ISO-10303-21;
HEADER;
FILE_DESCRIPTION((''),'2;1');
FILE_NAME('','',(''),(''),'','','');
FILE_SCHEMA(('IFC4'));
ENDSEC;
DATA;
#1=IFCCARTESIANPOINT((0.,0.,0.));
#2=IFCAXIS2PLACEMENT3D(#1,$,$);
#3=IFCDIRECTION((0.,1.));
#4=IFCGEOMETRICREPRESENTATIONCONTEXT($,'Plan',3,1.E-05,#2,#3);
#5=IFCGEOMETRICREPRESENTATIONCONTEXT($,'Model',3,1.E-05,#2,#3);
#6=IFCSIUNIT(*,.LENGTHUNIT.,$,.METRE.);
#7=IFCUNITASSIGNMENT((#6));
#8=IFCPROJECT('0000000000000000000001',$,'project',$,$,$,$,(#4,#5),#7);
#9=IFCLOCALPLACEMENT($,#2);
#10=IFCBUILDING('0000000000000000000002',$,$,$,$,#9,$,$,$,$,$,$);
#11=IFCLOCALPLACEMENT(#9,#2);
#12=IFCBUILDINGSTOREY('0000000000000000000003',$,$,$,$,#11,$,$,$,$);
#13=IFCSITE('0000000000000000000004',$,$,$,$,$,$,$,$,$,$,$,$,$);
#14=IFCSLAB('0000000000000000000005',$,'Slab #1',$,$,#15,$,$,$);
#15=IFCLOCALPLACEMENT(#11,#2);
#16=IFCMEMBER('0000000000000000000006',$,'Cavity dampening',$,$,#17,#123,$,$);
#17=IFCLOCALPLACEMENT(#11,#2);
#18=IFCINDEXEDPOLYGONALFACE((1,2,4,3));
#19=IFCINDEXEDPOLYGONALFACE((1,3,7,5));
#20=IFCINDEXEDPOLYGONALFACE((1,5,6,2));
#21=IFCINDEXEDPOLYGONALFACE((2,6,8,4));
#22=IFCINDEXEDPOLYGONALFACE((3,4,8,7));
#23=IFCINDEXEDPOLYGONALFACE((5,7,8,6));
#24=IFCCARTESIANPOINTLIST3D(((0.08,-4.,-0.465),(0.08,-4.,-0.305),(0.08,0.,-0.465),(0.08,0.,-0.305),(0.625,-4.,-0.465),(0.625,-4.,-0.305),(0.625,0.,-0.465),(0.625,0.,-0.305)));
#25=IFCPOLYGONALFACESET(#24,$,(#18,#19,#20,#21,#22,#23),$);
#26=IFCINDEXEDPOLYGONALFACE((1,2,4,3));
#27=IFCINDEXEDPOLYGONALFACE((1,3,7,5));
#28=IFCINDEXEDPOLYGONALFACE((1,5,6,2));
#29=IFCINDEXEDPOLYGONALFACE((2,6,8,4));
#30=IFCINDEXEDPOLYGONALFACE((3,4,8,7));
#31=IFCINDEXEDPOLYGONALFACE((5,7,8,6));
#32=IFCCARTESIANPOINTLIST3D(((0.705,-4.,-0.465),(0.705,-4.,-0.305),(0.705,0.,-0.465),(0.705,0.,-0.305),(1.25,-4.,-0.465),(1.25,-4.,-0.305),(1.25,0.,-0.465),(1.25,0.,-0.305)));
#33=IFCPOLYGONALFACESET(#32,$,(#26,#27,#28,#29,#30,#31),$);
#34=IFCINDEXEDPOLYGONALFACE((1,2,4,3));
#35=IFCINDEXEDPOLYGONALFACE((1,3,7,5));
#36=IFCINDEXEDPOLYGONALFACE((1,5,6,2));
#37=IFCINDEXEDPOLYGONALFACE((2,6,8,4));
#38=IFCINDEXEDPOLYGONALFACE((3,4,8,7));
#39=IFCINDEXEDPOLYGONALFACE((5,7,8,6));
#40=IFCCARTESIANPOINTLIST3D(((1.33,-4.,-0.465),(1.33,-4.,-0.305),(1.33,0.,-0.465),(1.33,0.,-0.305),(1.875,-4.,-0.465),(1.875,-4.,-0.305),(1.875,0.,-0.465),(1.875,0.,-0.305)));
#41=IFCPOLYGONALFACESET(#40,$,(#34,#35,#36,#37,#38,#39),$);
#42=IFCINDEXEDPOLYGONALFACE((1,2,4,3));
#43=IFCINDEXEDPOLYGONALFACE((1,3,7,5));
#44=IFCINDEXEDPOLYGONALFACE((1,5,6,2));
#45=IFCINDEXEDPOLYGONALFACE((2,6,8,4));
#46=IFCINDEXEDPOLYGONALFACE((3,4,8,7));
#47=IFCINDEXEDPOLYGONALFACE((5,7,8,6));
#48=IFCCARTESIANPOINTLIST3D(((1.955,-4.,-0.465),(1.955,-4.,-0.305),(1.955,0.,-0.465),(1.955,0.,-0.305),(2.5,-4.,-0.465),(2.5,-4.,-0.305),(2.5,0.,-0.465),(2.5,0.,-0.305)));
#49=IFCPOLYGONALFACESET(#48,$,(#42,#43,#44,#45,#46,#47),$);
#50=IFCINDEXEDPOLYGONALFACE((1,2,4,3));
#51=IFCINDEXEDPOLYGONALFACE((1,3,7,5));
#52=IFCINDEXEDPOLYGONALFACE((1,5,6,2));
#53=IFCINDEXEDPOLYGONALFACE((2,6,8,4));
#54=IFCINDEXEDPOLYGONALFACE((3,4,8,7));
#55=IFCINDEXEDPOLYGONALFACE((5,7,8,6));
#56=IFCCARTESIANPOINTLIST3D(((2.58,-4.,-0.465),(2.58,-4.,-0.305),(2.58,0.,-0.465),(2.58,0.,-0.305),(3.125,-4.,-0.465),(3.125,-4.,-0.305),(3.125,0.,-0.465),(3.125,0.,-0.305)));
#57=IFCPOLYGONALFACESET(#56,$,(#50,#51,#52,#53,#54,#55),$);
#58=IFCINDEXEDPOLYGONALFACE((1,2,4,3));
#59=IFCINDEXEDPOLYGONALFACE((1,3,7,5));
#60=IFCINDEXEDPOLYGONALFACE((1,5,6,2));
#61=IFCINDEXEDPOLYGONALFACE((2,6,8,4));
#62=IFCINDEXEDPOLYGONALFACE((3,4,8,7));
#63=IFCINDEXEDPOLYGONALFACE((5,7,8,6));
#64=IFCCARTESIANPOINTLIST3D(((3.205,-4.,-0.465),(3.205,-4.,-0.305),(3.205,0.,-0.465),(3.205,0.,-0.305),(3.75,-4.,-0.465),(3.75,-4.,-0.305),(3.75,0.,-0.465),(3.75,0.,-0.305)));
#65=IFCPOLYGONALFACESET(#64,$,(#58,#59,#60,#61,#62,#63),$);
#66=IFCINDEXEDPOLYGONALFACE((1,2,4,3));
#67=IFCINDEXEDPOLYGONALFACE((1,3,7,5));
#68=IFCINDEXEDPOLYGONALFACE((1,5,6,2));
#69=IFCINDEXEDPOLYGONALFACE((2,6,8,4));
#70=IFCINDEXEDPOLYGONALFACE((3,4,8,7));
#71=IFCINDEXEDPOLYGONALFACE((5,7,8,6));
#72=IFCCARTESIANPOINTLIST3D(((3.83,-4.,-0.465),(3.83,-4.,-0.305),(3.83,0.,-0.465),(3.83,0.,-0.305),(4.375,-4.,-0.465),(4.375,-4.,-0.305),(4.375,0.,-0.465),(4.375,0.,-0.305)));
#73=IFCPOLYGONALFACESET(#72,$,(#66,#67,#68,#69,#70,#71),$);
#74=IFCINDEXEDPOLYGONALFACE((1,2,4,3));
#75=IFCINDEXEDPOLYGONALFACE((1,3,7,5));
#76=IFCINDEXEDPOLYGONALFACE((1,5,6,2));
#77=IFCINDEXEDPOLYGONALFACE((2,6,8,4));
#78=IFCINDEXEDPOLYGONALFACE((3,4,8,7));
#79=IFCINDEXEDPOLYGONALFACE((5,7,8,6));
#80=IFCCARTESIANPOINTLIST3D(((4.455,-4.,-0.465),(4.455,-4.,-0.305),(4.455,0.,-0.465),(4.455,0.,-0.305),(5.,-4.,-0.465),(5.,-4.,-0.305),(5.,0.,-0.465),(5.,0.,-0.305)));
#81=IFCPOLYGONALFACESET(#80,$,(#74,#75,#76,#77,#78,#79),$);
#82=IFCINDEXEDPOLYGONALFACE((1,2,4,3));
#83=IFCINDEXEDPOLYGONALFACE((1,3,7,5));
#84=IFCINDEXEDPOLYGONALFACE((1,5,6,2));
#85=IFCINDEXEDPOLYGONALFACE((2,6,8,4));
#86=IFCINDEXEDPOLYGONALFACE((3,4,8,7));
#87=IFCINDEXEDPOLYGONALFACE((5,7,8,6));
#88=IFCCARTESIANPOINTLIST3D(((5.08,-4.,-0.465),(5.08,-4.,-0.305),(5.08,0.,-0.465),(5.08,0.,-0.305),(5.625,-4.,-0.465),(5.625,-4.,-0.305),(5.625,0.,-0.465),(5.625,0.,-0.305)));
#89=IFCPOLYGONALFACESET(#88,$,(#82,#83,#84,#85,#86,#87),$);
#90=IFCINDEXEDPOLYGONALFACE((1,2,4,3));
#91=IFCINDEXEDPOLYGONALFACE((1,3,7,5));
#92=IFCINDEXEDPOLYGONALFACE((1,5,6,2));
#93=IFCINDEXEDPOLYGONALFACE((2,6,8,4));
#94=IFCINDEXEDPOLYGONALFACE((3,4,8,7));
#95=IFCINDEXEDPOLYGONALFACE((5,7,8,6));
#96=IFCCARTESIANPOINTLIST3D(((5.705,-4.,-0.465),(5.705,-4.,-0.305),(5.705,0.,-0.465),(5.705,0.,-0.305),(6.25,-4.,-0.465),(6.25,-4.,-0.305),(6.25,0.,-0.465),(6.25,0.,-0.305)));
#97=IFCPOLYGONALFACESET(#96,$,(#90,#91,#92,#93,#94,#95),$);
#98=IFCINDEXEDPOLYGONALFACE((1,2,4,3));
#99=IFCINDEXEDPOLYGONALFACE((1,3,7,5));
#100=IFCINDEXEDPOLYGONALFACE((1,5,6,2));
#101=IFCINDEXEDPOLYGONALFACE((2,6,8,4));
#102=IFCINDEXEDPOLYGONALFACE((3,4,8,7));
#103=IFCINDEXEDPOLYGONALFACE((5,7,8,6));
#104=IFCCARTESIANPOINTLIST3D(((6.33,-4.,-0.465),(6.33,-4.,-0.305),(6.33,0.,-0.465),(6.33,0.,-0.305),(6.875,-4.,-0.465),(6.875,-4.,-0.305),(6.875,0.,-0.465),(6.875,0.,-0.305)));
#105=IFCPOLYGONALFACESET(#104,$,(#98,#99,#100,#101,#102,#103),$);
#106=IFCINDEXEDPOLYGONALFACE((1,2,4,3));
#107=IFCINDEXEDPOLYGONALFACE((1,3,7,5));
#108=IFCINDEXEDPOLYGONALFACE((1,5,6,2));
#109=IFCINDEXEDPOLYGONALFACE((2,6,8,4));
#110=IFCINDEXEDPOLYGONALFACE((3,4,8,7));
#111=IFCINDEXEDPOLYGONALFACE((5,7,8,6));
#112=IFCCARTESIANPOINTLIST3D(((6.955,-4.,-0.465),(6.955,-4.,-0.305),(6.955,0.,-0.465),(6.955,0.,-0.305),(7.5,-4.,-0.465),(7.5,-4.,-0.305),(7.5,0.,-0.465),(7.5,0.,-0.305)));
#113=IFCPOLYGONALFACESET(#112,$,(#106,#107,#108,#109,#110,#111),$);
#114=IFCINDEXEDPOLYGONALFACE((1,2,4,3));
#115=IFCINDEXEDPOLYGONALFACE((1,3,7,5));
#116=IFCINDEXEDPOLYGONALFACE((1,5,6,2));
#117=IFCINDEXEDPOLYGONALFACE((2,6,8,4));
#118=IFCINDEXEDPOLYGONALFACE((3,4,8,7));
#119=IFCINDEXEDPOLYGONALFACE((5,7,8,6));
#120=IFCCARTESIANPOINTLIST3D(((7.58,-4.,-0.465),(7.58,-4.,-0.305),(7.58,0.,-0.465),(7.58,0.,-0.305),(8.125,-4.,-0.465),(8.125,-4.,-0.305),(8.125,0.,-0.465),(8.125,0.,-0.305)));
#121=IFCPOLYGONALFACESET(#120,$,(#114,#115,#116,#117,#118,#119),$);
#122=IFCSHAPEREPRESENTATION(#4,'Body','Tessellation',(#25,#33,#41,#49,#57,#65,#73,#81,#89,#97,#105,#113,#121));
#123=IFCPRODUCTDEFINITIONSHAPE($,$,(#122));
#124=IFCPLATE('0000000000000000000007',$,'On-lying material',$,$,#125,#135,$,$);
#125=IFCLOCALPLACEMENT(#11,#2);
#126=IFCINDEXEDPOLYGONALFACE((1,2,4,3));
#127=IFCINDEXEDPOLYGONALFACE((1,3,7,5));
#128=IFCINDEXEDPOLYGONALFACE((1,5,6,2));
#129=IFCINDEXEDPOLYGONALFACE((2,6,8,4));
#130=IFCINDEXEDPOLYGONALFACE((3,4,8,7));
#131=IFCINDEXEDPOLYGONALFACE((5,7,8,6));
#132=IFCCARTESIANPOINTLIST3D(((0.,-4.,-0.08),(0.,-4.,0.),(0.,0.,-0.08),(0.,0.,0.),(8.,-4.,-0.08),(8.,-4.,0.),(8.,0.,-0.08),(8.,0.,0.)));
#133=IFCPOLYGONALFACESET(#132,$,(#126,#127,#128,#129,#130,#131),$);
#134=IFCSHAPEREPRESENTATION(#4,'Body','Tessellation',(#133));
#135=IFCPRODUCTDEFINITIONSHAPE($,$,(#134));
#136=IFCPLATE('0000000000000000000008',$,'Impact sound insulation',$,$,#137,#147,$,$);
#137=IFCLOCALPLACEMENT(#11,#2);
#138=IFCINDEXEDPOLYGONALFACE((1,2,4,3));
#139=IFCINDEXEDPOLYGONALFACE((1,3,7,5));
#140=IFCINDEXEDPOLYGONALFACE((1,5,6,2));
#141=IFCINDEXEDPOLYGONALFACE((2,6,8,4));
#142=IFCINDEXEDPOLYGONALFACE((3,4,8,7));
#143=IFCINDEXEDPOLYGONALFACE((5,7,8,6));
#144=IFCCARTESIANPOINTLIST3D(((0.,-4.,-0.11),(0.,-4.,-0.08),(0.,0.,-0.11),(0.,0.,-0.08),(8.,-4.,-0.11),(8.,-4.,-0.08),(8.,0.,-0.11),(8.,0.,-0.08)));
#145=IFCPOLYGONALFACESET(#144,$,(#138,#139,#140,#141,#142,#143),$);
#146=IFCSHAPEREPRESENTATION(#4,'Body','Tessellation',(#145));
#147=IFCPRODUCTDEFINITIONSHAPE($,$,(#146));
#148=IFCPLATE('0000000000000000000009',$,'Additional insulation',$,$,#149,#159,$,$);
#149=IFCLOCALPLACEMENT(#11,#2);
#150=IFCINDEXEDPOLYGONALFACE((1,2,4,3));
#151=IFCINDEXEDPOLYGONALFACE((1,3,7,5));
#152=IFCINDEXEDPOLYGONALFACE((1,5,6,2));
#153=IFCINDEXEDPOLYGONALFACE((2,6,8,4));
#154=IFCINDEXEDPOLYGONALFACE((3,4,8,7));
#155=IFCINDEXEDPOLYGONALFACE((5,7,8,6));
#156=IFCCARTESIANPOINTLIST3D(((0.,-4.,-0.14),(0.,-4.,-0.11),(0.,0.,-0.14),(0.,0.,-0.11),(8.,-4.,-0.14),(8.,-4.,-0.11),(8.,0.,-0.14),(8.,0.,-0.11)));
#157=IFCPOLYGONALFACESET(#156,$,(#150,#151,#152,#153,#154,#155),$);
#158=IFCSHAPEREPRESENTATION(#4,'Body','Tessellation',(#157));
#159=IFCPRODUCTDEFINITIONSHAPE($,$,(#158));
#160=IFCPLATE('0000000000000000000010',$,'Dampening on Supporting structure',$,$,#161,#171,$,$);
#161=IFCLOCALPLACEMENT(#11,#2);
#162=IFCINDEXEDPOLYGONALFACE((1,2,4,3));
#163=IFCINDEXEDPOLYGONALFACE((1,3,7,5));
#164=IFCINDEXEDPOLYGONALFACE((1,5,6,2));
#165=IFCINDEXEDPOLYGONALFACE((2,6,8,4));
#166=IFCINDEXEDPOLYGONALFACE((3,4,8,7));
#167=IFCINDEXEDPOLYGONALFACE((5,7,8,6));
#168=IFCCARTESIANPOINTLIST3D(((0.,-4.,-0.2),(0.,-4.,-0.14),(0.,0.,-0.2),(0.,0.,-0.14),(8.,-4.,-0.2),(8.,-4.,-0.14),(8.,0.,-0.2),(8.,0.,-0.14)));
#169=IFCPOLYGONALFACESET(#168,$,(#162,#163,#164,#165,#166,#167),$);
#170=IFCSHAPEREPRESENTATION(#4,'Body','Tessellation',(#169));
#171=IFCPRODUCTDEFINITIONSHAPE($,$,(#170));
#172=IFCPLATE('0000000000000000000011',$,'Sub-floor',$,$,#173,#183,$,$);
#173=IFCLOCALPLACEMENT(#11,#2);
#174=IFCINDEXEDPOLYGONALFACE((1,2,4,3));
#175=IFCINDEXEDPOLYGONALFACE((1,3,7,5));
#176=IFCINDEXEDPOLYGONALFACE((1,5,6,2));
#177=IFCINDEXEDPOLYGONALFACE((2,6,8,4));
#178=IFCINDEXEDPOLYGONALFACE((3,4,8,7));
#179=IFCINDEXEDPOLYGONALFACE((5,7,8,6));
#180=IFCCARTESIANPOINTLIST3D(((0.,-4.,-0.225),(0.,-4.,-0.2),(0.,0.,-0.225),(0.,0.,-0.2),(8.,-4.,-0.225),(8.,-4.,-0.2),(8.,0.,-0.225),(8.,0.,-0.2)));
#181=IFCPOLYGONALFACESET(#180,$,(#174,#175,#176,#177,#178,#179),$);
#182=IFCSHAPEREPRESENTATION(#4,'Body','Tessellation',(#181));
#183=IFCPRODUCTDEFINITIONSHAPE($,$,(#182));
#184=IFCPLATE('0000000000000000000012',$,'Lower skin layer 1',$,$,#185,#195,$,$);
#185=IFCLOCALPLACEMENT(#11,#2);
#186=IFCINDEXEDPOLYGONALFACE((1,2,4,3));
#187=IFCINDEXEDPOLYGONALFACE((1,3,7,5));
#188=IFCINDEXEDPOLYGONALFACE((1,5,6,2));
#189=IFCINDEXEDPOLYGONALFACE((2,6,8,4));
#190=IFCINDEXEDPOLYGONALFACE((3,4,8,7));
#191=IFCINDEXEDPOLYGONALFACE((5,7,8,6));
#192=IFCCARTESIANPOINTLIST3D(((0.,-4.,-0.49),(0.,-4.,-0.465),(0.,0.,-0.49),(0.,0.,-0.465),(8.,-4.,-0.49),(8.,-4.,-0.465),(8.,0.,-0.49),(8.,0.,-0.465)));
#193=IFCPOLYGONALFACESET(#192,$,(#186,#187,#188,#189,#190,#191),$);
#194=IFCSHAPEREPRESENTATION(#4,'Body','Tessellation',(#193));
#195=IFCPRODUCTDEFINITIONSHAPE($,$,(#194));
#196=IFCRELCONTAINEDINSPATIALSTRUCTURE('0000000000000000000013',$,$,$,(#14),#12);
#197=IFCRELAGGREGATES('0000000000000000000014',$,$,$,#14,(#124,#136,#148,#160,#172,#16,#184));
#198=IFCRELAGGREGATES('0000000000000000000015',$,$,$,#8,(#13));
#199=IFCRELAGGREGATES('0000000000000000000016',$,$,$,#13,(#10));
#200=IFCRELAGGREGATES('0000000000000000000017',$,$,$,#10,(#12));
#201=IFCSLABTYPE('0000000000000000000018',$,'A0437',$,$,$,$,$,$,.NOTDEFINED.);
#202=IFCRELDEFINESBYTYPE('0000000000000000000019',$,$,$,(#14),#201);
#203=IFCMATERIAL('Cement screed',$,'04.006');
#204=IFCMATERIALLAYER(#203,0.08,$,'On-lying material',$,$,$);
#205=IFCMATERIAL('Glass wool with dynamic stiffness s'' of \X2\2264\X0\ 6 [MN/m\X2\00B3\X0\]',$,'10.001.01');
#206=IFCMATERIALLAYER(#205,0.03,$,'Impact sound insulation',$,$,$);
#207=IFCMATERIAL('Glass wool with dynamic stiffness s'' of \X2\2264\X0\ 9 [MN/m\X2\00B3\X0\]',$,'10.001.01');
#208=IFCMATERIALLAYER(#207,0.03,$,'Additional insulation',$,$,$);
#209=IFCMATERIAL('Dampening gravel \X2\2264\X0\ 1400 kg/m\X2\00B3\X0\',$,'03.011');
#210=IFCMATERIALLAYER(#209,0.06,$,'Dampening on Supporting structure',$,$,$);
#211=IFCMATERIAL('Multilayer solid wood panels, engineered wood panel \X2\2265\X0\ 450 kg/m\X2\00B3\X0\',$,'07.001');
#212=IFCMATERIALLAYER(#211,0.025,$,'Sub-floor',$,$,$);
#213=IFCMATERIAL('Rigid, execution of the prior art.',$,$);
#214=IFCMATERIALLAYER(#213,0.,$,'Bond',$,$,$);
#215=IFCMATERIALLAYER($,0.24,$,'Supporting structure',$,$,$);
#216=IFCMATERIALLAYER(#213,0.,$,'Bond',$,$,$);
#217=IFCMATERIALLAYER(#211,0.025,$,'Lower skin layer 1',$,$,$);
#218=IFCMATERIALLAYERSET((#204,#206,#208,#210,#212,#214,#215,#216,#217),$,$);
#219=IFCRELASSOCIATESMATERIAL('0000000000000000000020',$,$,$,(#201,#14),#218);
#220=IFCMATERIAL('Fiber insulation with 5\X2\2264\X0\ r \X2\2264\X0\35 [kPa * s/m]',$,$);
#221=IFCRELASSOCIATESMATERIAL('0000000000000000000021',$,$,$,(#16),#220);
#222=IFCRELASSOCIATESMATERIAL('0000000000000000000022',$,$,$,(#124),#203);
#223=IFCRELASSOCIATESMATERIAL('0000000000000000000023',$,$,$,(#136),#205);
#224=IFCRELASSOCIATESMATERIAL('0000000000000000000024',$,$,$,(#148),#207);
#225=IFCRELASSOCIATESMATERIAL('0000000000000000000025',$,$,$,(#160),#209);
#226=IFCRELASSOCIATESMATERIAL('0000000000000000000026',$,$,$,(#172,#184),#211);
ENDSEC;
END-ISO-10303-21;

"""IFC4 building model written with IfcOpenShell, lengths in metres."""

from ifc_helpers import new_model, si_unit, direction, frame, frame_2d, origin, origin_with_axes, place, context, project, spatial, rectangle, extrude, material, layer, layer_set, type_object, element, aggregate, save


model = new_model("IFC4")

# Units and contexts
plan_context = context("Plan", 3, precision=1e-05, world=origin(), true_north=direction((0.0, 1.0)))
model_context = context("Model", 3, precision=1e-05, world=origin(), true_north=direction((0.0, 1.0)))
ifc_project = project(units=[si_unit("LENGTHUNIT", "METRE")], contexts=[plan_context, model_context])

# Site, building, storey
site = spatial("IfcSite", under=ifc_project)
building_placement = place(None, origin())
building = spatial("IfcBuilding", under=site, at=building_placement)
storey_placement = place(building_placement, origin())
storey = spatial("IfcBuildingStorey", under=building, at=storey_placement)

# Slab, member, plates
ifc_material_1 = material(Name="Cement screed", Category="04.006")
ifc_layer_1 = layer(ifc_material_1, 0.08, Name="On-lying material")
ifc_material_2 = material(Name="Glass wool with dynamic stiffness s' of ≤ 6 [MN/m³]", Category="10.001.01")
ifc_layer_2 = layer(ifc_material_2, 0.03, Name="Impact sound insulation")
ifc_material_3 = material(Name="Glass wool with dynamic stiffness s' of ≤ 9 [MN/m³]", Category="10.001.01")
ifc_layer_3 = layer(ifc_material_3, 0.03, Name="Additional insulation")
ifc_material_4 = material(Name="Dampening gravel ≤ 1400 kg/m³", Category="03.011")
ifc_layer_4 = layer(ifc_material_4, 0.06, Name="Dampening on Supporting structure")
ifc_material_5 = material(Name="Multilayer solid wood panels, engineered wood panel ≥ 450 kg/m³", Category="07.001")
ifc_layer_5 = layer(ifc_material_5, 0.025, Name="Sub-floor")
ifc_material_6 = material(Name="Rigid, execution of the prior art.")
ifc_layer_6 = layer(ifc_material_6, 0.0, Name="Bond")
ifc_layer_7 = layer(None, 0.24, Name="Supporting structure")
ifc_layer_8 = layer(ifc_material_6, 0.0, Name="Bond")
ifc_layer_9 = layer(ifc_material_5, 0.025, Name="Lower skin layer 1")
ifc_layer_set = layer_set([ifc_layer_1, ifc_layer_2, ifc_layer_3, ifc_layer_4, ifc_layer_5, ifc_layer_6, ifc_layer_7, ifc_layer_8, ifc_layer_9])
slab_type = type_object("IfcSlabType", Name="A0437", PredefinedType="NOTDEFINED", material=ifc_layer_set)
slab_placement = place(None, frame((0.0, 0.0, 0.0), z_axis=(0.0, 0.0, -1.0), x_axis=(1.0, 0.0, 0.0)))
slab = element("IfcSlab", 1, at=slab_placement, inside=storey, type_object=slab_type, material=ifc_layer_set, Name="Slab #1")
ifc_material_7 = material(Name="Fiber insulation with 5≤ r ≤35 [kPa * s/m]")
member_1_placement = place(slab_placement, origin())
member_1 = element("IfcMember", 2, at=member_1_placement, material=ifc_material_7, Name="Cavity dampening", context=plan_context, shape_type="SweptSolid", body=[
    extrude(rectangle(XDim=0.545, YDim=0.16, at=frame_2d((0.2725, 0.08), x_axis=(1.0, 0.0))), frame((0.08, 4.0, 0.305), z_axis=(0.0, -1.0, 0.0), x_axis=(1.0, 0.0, 0.0)), (0.0, 0.0, 1.0), 4.0),
    extrude(rectangle(XDim=0.545, YDim=0.16, at=frame_2d((0.2725, 0.08), x_axis=(1.0, 0.0))), frame((0.705, 4.0, 0.305), z_axis=(0.0, -1.0, 0.0), x_axis=(1.0, 0.0, 0.0)), (0.0, 0.0, 1.0), 4.0),
    extrude(rectangle(XDim=0.545, YDim=0.16, at=frame_2d((0.2725, 0.08), x_axis=(1.0, 0.0))), frame((1.33, 4.0, 0.305), z_axis=(0.0, -1.0, 0.0), x_axis=(1.0, 0.0, 0.0)), (0.0, 0.0, 1.0), 4.0),
    extrude(rectangle(XDim=0.545, YDim=0.16, at=frame_2d((0.2725, 0.08), x_axis=(1.0, 0.0))), frame((1.955, 4.0, 0.305), z_axis=(0.0, -1.0, 0.0), x_axis=(1.0, 0.0, 0.0)), (0.0, 0.0, 1.0), 4.0),
    extrude(rectangle(XDim=0.545, YDim=0.16, at=frame_2d((0.2725, 0.08), x_axis=(1.0, 0.0))), frame((2.58, 4.0, 0.305), z_axis=(0.0, -1.0, 0.0), x_axis=(1.0, 0.0, 0.0)), (0.0, 0.0, 1.0), 4.0),
    extrude(rectangle(XDim=0.545, YDim=0.16, at=frame_2d((0.2725, 0.08), x_axis=(1.0, 0.0))), frame((3.205, 4.0, 0.305), z_axis=(0.0, -1.0, 0.0), x_axis=(1.0, 0.0, 0.0)), (0.0, 0.0, 1.0), 4.0),
    extrude(rectangle(XDim=0.545, YDim=0.16, at=frame_2d((0.2725, 0.08), x_axis=(1.0, 0.0))), frame((3.83, 4.0, 0.305), z_axis=(0.0, -1.0, 0.0), x_axis=(1.0, 0.0, 0.0)), (0.0, 0.0, 1.0), 4.0),
    extrude(rectangle(XDim=0.545, YDim=0.16, at=frame_2d((0.2725, 0.08), x_axis=(1.0, 0.0))), frame((4.455, 4.0, 0.305), z_axis=(0.0, -1.0, 0.0), x_axis=(1.0, 0.0, 0.0)), (0.0, 0.0, 1.0), 4.0),
    extrude(rectangle(XDim=0.545, YDim=0.16, at=frame_2d((0.2725, 0.08), x_axis=(1.0, 0.0))), frame((5.08, 4.0, 0.305), z_axis=(0.0, -1.0, 0.0), x_axis=(1.0, 0.0, 0.0)), (0.0, 0.0, 1.0), 4.0),
    extrude(rectangle(XDim=0.545, YDim=0.16, at=frame_2d((0.2725, 0.08), x_axis=(1.0, 0.0))), frame((5.705, 4.0, 0.305), z_axis=(0.0, -1.0, 0.0), x_axis=(1.0, 0.0, 0.0)), (0.0, 0.0, 1.0), 4.0),
    extrude(rectangle(XDim=0.545, YDim=0.16, at=frame_2d((0.2725, 0.08), x_axis=(1.0, 0.0))), frame((6.33, 4.0, 0.305), z_axis=(0.0, -1.0, 0.0), x_axis=(1.0, 0.0, 0.0)), (0.0, 0.0, 1.0), 4.0),
    extrude(rectangle(XDim=0.545, YDim=0.16, at=frame_2d((0.2725, 0.08), x_axis=(1.0, 0.0))), frame((6.955, 4.0, 0.305), z_axis=(0.0, -1.0, 0.0), x_axis=(1.0, 0.0, 0.0)), (0.0, 0.0, 1.0), 4.0),
    extrude(rectangle(XDim=0.545, YDim=0.16, at=frame_2d((0.2725, 0.08), x_axis=(1.0, 0.0))), frame((7.58, 4.0, 0.305), z_axis=(0.0, -1.0, 0.0), x_axis=(1.0, 0.0, 0.0)), (0.0, 0.0, 1.0), 4.0),
])
plate_1_placement = place(slab_placement, origin())
plate_1 = element("IfcPlate", 3, at=plate_1_placement, material=ifc_material_1, Name="On-lying material", context=plan_context, shape_type="SweptSolid", body=[
    extrude(rectangle(XDim=8.0, YDim=4.0, at=frame_2d((4.0, 2.0), x_axis=(1.0, 0.0))), origin_with_axes(), (0.0, 0.0, 1.0), 0.08),
])
plate_2_placement = place(slab_placement, origin())
plate_2 = element("IfcPlate", 4, at=plate_2_placement, material=ifc_material_2, Name="Impact sound insulation", context=plan_context, shape_type="SweptSolid", body=[
    extrude(rectangle(XDim=8.0, YDim=4.0, at=frame_2d((4.0, 2.0), x_axis=(1.0, 0.0))), frame((0.0, 0.0, 0.08), z_axis=(0.0, 0.0, 1.0), x_axis=(1.0, 0.0, 0.0)), (0.0, 0.0, 1.0), 0.03),
])
plate_3_placement = place(slab_placement, origin())
plate_3 = element("IfcPlate", 5, at=plate_3_placement, material=ifc_material_3, Name="Additional insulation", context=plan_context, shape_type="SweptSolid", body=[
    extrude(rectangle(XDim=8.0, YDim=4.0, at=frame_2d((4.0, 2.0), x_axis=(1.0, 0.0))), frame((0.0, 0.0, 0.11), z_axis=(0.0, 0.0, 1.0), x_axis=(1.0, 0.0, 0.0)), (0.0, 0.0, 1.0), 0.03),
])
plate_4_placement = place(slab_placement, origin())
plate_4 = element("IfcPlate", 6, at=plate_4_placement, material=ifc_material_4, Name="Dampening on Supporting structure", context=plan_context, shape_type="SweptSolid", body=[
    extrude(rectangle(XDim=8.0, YDim=4.0, at=frame_2d((4.0, 2.0), x_axis=(1.0, 0.0))), frame((0.0, 0.0, 0.14), z_axis=(0.0, 0.0, 1.0), x_axis=(1.0, 0.0, 0.0)), (0.0, 0.0, 1.0), 0.06),
])
plate_5_placement = place(slab_placement, origin())
plate_5 = element("IfcPlate", 7, at=plate_5_placement, material=ifc_material_5, Name="Sub-floor", context=plan_context, shape_type="SweptSolid", body=[
    extrude(rectangle(XDim=8.0, YDim=4.0, at=frame_2d((4.0, 2.0), x_axis=(1.0, 0.0))), frame((0.0, 0.0, 0.2), z_axis=(0.0, 0.0, 1.0), x_axis=(1.0, 0.0, 0.0)), (0.0, 0.0, 1.0), 0.025),
])
plate_6_placement = place(slab_placement, origin())
plate_6 = element("IfcPlate", 8, at=plate_6_placement, material=ifc_material_5, Name="Lower skin layer 1", context=plan_context, shape_type="SweptSolid", body=[
    extrude(rectangle(XDim=8.0, YDim=4.0, at=frame_2d((4.0, 2.0), x_axis=(1.0, 0.0))), frame((0.0, 0.0, 0.465), z_axis=(0.0, 0.0, 1.0), x_axis=(1.0, 0.0, 0.0)), (0.0, 0.0, 1.0), 0.025),
])
aggregate(slab, [plate_1, plate_2, plate_3, plate_4, plate_5, member_1, plate_6])

save(model, "model.ifc")
